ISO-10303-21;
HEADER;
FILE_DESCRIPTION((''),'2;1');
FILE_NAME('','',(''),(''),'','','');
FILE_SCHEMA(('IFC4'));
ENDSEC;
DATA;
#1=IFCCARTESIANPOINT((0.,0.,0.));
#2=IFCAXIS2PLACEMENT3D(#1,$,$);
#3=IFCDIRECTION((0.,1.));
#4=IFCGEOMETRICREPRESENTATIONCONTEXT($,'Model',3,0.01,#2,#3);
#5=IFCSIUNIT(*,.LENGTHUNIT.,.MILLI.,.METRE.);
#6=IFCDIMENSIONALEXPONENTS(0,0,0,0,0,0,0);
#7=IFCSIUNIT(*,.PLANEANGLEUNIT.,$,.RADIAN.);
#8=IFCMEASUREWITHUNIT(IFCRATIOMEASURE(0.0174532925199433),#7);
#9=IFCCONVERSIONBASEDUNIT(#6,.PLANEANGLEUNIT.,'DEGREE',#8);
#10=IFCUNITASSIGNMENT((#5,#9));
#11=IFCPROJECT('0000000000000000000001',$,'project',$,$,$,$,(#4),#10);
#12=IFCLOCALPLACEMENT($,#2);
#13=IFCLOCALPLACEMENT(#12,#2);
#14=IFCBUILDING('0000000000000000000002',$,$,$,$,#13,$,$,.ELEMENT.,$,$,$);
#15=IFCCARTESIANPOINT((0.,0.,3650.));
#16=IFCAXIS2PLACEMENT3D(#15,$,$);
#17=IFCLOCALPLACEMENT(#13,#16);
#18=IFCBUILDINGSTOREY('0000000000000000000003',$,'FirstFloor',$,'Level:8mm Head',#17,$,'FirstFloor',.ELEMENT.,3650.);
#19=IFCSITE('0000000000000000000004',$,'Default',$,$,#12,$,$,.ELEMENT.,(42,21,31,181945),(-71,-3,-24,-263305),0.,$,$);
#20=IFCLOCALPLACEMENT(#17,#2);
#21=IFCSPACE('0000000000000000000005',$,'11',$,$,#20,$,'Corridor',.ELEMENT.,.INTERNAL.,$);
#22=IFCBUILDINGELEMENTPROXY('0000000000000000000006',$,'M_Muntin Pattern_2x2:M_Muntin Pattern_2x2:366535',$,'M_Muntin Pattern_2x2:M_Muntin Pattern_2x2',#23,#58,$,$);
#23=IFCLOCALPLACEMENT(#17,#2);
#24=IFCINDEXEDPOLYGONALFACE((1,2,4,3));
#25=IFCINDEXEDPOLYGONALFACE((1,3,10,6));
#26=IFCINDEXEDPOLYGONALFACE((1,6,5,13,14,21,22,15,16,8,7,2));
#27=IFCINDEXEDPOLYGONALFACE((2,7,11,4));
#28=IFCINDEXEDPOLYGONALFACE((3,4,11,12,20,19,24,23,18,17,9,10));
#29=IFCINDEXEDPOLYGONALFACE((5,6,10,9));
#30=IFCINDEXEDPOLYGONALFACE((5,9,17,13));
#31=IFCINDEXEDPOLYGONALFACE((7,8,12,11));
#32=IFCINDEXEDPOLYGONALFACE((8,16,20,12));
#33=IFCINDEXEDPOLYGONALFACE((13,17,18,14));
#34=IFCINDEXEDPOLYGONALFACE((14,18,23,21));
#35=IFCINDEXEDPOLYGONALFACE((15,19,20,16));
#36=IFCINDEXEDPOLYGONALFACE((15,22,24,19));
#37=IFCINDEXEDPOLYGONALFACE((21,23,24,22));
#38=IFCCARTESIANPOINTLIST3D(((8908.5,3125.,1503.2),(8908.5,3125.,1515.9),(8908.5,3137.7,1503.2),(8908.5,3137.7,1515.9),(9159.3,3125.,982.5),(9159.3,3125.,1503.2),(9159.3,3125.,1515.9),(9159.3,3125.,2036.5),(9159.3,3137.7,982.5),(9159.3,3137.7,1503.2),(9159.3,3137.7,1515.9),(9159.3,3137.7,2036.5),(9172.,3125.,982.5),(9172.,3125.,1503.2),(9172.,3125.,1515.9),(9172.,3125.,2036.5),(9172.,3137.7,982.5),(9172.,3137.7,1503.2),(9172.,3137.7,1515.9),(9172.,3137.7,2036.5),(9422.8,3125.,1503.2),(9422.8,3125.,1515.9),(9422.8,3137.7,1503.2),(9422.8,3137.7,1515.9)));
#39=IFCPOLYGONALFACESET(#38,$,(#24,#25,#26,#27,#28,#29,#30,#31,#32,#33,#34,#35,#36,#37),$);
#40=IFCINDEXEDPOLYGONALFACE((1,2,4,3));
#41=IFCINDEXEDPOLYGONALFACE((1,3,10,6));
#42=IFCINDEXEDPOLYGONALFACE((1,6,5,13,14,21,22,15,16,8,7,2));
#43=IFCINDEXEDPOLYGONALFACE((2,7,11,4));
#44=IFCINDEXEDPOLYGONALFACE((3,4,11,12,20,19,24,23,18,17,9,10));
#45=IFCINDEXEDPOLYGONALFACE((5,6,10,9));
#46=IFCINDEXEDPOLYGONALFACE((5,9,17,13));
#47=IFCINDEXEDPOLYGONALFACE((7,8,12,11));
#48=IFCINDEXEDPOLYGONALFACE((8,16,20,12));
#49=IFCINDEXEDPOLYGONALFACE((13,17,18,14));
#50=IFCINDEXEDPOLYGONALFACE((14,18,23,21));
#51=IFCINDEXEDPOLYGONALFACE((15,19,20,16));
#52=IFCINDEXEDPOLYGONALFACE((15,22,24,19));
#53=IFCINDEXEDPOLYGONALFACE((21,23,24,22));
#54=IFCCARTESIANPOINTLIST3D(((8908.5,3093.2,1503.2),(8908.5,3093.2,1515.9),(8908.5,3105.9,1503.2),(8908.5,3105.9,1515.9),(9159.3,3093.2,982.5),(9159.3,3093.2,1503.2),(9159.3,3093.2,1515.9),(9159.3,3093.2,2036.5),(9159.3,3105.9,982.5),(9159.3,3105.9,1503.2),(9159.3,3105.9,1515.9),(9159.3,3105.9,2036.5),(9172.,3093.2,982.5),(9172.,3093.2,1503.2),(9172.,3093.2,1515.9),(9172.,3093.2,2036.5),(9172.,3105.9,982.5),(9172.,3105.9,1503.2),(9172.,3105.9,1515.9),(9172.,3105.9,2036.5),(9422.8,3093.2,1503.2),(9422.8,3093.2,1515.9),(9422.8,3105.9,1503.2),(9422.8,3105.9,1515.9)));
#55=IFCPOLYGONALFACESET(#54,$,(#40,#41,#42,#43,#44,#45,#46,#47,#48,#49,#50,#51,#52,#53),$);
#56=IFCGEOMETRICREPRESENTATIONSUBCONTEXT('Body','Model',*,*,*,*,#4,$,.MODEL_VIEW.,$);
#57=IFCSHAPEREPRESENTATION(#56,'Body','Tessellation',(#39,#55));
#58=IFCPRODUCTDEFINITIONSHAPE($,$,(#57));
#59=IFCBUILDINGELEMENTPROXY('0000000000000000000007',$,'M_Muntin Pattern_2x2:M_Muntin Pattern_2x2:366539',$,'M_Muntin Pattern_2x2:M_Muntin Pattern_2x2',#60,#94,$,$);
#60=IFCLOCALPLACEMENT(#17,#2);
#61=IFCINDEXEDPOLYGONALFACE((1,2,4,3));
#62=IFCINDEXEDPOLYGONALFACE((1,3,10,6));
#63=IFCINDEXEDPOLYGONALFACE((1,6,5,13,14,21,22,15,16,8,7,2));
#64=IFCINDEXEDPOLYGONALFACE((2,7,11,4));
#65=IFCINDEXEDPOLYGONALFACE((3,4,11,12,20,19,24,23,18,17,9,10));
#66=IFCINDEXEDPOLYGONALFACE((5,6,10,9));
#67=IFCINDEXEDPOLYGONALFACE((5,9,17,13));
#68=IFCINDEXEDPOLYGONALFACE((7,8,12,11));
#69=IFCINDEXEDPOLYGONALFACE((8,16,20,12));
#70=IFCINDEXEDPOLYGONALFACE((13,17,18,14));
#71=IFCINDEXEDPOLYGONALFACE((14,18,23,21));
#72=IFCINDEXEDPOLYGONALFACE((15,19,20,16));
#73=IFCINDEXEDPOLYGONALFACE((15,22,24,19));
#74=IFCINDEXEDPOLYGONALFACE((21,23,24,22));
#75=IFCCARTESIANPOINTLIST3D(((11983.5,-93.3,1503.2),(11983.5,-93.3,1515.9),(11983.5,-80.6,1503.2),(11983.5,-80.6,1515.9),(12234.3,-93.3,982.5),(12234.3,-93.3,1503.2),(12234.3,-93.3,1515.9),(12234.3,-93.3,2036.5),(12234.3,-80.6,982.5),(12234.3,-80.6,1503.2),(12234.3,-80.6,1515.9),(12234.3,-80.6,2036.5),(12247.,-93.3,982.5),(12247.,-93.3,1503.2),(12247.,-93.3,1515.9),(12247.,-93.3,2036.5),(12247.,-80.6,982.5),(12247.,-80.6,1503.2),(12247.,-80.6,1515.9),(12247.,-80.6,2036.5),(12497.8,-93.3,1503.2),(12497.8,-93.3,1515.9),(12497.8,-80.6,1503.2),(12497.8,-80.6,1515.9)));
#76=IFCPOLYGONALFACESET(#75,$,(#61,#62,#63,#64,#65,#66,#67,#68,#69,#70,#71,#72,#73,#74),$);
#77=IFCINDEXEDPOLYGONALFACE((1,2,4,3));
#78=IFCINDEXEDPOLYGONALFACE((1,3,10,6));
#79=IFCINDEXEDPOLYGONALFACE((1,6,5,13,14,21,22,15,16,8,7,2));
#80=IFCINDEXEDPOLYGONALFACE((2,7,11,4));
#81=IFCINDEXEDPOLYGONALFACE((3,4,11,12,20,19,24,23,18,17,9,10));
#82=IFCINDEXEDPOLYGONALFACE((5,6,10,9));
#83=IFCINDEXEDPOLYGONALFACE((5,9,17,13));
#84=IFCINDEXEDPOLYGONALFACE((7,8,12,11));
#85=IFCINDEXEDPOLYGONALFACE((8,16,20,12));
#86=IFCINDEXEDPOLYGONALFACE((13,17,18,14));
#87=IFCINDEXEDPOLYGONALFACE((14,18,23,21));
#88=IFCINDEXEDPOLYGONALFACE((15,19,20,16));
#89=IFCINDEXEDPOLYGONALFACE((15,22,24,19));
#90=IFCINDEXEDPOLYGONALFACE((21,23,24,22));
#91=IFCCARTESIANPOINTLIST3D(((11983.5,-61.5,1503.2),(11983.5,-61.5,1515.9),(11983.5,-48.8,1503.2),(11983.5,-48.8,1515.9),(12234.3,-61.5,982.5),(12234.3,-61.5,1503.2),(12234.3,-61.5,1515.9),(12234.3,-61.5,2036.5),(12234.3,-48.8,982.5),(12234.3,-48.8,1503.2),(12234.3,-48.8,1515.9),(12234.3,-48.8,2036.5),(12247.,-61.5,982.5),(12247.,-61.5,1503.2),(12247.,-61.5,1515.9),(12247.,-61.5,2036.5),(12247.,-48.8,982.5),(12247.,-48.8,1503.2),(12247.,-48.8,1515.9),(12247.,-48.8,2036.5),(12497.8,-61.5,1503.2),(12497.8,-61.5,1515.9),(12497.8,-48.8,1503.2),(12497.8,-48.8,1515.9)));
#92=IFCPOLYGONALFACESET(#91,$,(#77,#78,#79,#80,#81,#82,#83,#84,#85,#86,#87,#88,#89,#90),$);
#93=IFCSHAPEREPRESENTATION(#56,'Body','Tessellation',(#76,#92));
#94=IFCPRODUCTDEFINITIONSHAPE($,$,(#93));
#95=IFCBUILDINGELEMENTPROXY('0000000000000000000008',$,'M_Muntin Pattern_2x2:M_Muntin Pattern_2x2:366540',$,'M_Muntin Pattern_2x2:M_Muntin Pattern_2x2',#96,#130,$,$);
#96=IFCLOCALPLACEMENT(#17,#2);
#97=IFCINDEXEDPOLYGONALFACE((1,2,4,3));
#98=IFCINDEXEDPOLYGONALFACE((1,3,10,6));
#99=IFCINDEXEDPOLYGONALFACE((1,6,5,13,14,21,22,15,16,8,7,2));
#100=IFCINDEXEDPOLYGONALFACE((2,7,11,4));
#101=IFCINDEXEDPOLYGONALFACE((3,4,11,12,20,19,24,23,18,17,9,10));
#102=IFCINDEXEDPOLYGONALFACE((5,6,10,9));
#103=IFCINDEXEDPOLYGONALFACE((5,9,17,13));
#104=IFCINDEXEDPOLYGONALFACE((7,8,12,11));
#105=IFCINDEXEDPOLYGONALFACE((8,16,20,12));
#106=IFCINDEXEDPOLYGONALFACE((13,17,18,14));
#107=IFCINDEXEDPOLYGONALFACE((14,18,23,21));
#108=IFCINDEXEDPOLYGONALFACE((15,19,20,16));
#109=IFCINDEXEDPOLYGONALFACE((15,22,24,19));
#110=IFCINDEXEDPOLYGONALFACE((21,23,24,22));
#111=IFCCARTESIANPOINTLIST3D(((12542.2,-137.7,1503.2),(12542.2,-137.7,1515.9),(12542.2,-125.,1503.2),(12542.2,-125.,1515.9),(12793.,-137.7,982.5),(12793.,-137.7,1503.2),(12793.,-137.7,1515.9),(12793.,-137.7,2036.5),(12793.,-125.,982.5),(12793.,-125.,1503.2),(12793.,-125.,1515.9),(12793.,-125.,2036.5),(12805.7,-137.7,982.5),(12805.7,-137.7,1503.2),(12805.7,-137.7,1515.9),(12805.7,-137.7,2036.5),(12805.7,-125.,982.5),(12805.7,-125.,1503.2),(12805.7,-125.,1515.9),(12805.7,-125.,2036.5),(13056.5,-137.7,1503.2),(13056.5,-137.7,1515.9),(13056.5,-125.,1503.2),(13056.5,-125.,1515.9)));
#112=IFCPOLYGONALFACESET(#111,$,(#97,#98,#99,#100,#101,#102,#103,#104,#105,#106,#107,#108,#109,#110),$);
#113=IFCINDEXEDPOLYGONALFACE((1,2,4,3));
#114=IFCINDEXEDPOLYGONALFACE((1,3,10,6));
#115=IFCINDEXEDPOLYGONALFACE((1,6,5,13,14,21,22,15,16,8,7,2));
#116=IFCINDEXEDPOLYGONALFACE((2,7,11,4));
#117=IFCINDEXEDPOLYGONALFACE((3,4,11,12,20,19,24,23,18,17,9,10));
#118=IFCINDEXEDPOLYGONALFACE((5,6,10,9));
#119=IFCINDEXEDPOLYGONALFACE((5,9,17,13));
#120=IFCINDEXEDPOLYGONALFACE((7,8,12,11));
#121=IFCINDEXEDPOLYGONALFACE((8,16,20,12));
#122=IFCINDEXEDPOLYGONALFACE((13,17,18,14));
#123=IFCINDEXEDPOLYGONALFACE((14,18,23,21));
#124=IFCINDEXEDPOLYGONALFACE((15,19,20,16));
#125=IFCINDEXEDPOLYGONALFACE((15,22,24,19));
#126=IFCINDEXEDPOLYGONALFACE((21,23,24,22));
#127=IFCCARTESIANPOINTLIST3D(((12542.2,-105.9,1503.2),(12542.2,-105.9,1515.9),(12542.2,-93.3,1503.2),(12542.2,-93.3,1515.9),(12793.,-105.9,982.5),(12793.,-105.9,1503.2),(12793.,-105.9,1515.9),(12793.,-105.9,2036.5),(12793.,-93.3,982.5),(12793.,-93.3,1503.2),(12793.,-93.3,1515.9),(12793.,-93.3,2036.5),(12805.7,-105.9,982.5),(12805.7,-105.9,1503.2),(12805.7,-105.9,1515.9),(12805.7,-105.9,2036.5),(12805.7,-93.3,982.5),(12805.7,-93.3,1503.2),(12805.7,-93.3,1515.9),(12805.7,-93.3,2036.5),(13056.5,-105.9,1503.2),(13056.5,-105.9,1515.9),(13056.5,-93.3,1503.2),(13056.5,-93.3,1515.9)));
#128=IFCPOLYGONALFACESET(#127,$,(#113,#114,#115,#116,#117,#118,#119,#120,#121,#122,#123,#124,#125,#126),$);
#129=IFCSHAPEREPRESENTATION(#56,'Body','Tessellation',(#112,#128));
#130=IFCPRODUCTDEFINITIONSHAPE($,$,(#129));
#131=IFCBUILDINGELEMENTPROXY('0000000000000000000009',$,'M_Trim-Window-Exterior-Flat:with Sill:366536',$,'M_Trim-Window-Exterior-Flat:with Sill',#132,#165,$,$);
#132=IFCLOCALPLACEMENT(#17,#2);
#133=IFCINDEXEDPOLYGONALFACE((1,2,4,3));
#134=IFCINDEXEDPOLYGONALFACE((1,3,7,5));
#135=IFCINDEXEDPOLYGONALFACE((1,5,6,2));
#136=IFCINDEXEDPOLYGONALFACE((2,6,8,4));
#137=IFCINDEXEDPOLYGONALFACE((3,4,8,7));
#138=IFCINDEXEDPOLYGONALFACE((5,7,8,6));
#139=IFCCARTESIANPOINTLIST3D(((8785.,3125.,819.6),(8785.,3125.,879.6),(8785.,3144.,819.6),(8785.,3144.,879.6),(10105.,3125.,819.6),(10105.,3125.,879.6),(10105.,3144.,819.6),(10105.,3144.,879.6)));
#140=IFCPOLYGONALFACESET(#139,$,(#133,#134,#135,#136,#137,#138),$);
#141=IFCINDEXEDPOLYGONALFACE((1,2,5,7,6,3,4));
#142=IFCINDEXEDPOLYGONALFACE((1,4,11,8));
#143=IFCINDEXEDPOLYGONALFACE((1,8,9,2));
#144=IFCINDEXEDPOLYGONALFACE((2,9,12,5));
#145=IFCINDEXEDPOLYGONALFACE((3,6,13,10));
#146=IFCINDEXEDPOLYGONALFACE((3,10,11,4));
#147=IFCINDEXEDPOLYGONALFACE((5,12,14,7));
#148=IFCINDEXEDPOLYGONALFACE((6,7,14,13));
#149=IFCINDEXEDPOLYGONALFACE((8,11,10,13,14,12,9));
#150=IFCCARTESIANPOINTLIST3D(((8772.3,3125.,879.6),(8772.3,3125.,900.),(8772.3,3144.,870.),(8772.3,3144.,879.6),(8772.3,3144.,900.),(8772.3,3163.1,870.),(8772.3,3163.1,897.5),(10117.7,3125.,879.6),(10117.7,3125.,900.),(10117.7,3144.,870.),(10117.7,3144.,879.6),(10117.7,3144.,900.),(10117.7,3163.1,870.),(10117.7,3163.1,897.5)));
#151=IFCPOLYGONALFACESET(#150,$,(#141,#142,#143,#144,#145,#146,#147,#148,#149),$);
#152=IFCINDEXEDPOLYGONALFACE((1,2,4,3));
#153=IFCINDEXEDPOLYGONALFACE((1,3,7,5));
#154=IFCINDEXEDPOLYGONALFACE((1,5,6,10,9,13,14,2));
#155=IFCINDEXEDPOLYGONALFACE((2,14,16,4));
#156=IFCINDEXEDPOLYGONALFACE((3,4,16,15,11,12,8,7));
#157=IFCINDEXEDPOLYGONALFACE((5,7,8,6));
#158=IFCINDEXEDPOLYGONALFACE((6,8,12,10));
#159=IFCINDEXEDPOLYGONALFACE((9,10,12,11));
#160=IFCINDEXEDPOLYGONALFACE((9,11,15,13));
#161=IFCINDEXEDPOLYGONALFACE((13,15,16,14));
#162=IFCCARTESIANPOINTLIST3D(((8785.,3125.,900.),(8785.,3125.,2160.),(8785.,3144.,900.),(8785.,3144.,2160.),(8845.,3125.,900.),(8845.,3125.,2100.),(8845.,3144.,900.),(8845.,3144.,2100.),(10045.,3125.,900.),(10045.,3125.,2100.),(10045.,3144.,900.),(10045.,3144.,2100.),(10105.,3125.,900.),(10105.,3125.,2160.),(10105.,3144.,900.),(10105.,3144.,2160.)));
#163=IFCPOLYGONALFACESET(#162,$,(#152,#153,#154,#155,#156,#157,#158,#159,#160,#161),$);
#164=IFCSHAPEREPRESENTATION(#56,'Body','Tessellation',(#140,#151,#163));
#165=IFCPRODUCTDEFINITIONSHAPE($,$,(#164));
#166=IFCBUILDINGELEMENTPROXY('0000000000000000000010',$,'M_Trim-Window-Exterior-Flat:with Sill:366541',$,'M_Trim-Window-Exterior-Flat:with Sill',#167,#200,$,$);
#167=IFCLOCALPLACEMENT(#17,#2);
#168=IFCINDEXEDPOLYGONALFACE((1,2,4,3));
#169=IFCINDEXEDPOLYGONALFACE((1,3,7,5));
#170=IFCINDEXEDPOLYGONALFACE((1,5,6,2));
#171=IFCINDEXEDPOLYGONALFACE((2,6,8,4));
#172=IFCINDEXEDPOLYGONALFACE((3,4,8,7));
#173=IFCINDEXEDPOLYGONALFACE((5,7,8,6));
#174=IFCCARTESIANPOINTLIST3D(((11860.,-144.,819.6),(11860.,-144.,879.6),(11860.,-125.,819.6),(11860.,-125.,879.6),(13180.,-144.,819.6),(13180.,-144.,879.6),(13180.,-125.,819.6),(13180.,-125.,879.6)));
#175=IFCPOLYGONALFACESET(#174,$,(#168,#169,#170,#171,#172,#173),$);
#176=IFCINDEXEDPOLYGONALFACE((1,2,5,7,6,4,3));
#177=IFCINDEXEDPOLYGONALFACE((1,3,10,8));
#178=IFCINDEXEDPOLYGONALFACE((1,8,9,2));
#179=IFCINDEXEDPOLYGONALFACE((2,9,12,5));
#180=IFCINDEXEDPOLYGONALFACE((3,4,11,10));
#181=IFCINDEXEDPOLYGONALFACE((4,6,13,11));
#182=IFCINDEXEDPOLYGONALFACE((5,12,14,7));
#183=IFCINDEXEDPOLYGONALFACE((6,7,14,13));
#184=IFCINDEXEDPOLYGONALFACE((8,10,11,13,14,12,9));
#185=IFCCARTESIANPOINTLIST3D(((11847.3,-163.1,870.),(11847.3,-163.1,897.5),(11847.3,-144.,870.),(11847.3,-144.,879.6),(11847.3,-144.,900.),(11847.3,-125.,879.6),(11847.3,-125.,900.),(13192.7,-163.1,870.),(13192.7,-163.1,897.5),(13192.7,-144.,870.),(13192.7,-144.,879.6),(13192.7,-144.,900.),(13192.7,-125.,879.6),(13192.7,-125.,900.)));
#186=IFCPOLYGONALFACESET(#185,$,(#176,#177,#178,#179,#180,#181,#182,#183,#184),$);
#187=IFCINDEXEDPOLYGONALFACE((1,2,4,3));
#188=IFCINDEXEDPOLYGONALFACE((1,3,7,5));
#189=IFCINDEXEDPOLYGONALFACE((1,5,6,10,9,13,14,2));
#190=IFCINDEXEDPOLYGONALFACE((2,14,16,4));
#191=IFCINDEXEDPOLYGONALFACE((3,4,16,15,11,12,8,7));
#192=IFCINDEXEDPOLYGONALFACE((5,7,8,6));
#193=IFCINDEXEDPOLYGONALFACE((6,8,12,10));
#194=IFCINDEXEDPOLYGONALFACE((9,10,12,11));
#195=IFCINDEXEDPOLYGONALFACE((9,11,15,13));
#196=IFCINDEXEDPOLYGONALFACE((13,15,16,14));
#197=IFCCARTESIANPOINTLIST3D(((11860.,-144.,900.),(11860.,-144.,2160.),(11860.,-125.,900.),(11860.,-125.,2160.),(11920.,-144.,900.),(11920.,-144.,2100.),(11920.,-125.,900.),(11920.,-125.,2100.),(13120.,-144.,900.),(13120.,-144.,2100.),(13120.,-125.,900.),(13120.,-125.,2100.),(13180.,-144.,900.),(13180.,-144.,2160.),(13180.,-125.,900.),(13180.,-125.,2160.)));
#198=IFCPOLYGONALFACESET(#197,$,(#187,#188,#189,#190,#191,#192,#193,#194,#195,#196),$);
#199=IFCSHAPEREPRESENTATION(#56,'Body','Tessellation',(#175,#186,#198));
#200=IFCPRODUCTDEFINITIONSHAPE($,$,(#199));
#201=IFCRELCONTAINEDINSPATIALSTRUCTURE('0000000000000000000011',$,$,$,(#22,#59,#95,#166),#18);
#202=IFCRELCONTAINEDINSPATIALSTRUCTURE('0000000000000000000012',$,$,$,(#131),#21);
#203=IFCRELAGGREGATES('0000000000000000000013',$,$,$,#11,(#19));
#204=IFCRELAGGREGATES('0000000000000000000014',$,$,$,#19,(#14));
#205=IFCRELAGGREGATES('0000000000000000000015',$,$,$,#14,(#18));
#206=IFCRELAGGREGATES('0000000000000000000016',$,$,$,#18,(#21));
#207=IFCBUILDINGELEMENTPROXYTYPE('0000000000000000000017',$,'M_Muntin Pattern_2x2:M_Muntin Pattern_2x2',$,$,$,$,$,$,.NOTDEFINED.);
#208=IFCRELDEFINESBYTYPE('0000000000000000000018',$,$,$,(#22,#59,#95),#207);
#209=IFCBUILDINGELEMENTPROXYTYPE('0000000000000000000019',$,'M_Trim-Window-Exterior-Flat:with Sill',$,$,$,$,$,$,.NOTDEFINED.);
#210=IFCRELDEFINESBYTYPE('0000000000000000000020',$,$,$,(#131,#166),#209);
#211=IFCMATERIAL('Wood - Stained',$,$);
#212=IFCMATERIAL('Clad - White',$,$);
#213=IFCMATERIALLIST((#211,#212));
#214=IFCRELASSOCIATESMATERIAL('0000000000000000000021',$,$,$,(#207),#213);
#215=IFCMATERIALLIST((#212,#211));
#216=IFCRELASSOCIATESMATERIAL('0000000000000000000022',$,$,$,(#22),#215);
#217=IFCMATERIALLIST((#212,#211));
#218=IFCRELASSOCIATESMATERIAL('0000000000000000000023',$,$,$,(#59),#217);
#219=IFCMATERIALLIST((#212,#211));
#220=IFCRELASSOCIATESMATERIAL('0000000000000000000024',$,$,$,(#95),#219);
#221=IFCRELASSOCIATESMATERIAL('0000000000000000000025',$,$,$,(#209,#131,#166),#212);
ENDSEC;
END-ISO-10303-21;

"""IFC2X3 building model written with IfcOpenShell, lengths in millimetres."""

from ifc_helpers import new_model, entity, si_unit, converted_unit, direction, frame, frame_2d, origin, place, context, subcontext, project, spatial, polyline, rectangle, outline, extrude, source, transform, mapped, material, material_list, type_object, type_shapes, element, save


model = new_model("IFC2X3")

# Units and contexts
model_context = context("Model", 3, precision=0.01, world=origin(), true_north=direction((0.0, 1.0)))
body_context = subcontext(model_context, "Body", "Model", "MODEL_VIEW")
ifc_project = project(units=[si_unit("LENGTHUNIT", "METRE", prefix="MILLI"), converted_unit("PLANEANGLEUNIT", "DEGREE", entity("IfcRatioMeasure", 0.0174532925199433), si_unit("PLANEANGLEUNIT", "RADIAN"), dimensions=[0, 0, 0, 0, 0, 0, 0])], contexts=[model_context])

# Site, building, storey
site_placement = place(None, origin())
site = spatial("IfcSite", under=ifc_project, at=site_placement, Name="Default", CompositionType="ELEMENT", RefLatitude=(42, 21, 31, 181945), RefLongitude=(-71, -3, -24, -263305), RefElevation=0.0)
building_placement = place(site_placement, origin())
building = spatial("IfcBuilding", under=site, at=building_placement, CompositionType="ELEMENT")
storey_placement = place(building_placement, frame((0.0, 0.0, 3650.0)))
storey = spatial("IfcBuildingStorey", under=building, at=storey_placement, Name="FirstFloor", ObjectType="Level:8mm Head", LongName="FirstFloor", CompositionType="ELEMENT", Elevation=3650.0)

# Building element proxies
ifc_material_1 = material(Name="Clad - White")
ifc_material_2 = material(Name="Wood - Stained")
ifc_material_list_1 = material_list([ifc_material_2, ifc_material_1])
building_element_proxy_type_1 = type_object("IfcBuildingElementProxyType", Name="M_Muntin Pattern_2x2:M_Muntin Pattern_2x2", PredefinedType="NOTDEFINED", material=ifc_material_list_1)
shared_shape_1 = source(origin(), body_context, "Body", "SweptSolid", [
    extrude(outline(polyline([(6.4, -6.4), (527.0, -6.4), (527.0, 6.3), (6.4, 6.3), (6.4, 257.1), (-6.3, 257.1), (-6.3, 6.3), (-527.0, 6.3), (-527.0, -6.4), (-6.3, -6.4), (-6.3, -257.1), (6.4, -257.1), (6.4, -6.4)])), frame((0.0, 9.5, 527.0), z_axis=(0.0, 1.0, 0.0), x_axis=(0.0, 0.0, 1.0)), (0.0, 0.0, 1.0), 12.7),
    extrude(outline(polyline([(6.4, -6.4), (527.0, -6.4), (527.0, 6.3), (6.4, 6.3), (6.4, 257.1), (-6.3, 257.1), (-6.3, 6.3), (-527.0, 6.3), (-527.0, -6.4), (-6.3, -6.4), (-6.3, -257.1), (6.4, -257.1), (6.4, -6.4)])), frame((0.0, -22.2, 527.0), z_axis=(0.0, 1.0, 0.0), x_axis=(0.0, 0.0, 1.0)), (0.0, 0.0, 1.0), 12.7),
])
type_shapes(building_element_proxy_type_1, [shared_shape_1])
ifc_material_list_2 = material_list([ifc_material_1, ifc_material_2])
proxy_1_placement = place(storey_placement, frame((9165.6, 3115.5, 982.5)))
element("IfcBuildingElementProxy", 1, at=proxy_1_placement, inside=storey, type_object=building_element_proxy_type_1, material=ifc_material_list_2, Name="M_Muntin Pattern_2x2:M_Muntin Pattern_2x2:366535", ObjectType="M_Muntin Pattern_2x2:M_Muntin Pattern_2x2", context=body_context, shape_type="MappedRepresentation", body=[
    mapped(shared_shape_1, transform((0.0, 0.0, 0.0), scale=1.0)),
])
ifc_material_list_3 = material_list([ifc_material_1, ifc_material_2])
proxy_2_placement = place(storey_placement, frame((12240.6, -71.0, 982.5), z_axis=(0.0, 0.0, 1.0), x_axis=(-1.0, 0.0, 0.0)))
element("IfcBuildingElementProxy", 2, at=proxy_2_placement, inside=storey, type_object=building_element_proxy_type_1, material=ifc_material_list_3, Name="M_Muntin Pattern_2x2:M_Muntin Pattern_2x2:366539", ObjectType="M_Muntin Pattern_2x2:M_Muntin Pattern_2x2", context=body_context, shape_type="MappedRepresentation", body=[
    mapped(shared_shape_1, transform((0.0, 0.0, 0.0), scale=1.0)),
])
ifc_material_list_4 = material_list([ifc_material_1, ifc_material_2])
proxy_3_placement = place(storey_placement, frame((12799.4, -115.5, 982.5), z_axis=(0.0, 0.0, 1.0), x_axis=(-1.0, 0.0, 0.0)))
element("IfcBuildingElementProxy", 3, at=proxy_3_placement, inside=storey, type_object=building_element_proxy_type_1, material=ifc_material_list_4, Name="M_Muntin Pattern_2x2:M_Muntin Pattern_2x2:366540", ObjectType="M_Muntin Pattern_2x2:M_Muntin Pattern_2x2", context=body_context, shape_type="MappedRepresentation", body=[
    mapped(shared_shape_1, transform((0.0, 0.0, 0.0), scale=1.0)),
])

# Shared definitions
space_1_placement = place(storey_placement, origin())
space_1 = spatial("IfcSpace", under=storey, at=space_1_placement, Name="11", LongName="Corridor", CompositionType="ELEMENT", InteriorOrExteriorSpace="INTERNAL")

# Building element proxies
building_element_proxy_type_2 = type_object("IfcBuildingElementProxyType", Name="M_Trim-Window-Exterior-Flat:with Sill", PredefinedType="NOTDEFINED", material=ifc_material_1)
shared_shape_2 = source(origin(), body_context, "Body", "SweptSolid", [
    extrude(rectangle(XDim=1320.0, YDim=60.0, at=frame_2d((0.0, 0.0), x_axis=(1.0, 0.0))), frame((0.0, -1250.4, 0.0), z_axis=(0.0, 0.0, 1.0), x_axis=(-1.0, 0.0, 0.0)), (0.0, 0.0, 1.0), 19.1),
    extrude(outline(polyline([(-19.0, -15.2), (0.0, -15.2), (0.0, -5.7), (19.0, -5.7), (19.0, 14.8), (0.0, 14.8), (-19.0, 12.3), (-19.0, -15.2)])), frame((-672.7, -1214.8, 19.0), z_axis=(1.0, 0.0, 0.0), x_axis=(0.0, 0.0, -1.0)), (0.0, 0.0, 1.0), 1345.4),
    extrude(outline(polyline([(-645.0, -660.0), (615.0, -660.0), (615.0, -600.0), (-585.0, -600.0), (-585.0, 600.0), (615.0, 600.0), (615.0, 660.0), (-645.0, 660.0), (-645.0, -660.0)])), frame((0.0, -585.0, 0.0), z_axis=(0.0, 0.0, 1.0), x_axis=(0.0, -1.0, 0.0)), (0.0, 0.0, 1.0), 19.1),
])
type_shapes(building_element_proxy_type_2, [shared_shape_2])
proxy_4_placement = place(space_1_placement, frame((9445.0, 3125.0, 2100.0), z_axis=(0.0, 1.0, 0.0), x_axis=(-1.0, 0.0, 0.0)))
element("IfcBuildingElementProxy", 4, at=proxy_4_placement, inside=space_1, type_object=building_element_proxy_type_2, material=ifc_material_1, Name="M_Trim-Window-Exterior-Flat:with Sill:366536", ObjectType="M_Trim-Window-Exterior-Flat:with Sill", context=body_context, shape_type="MappedRepresentation", body=[
    mapped(shared_shape_2, transform((0.0, 0.0, 0.0), scale=1.0)),
])
proxy_5_placement = place(storey_placement, frame((12520.0, -125.0, 2100.0), z_axis=(0.0, -1.0, 0.0), x_axis=(1.0, 0.0, 0.0)))
element("IfcBuildingElementProxy", 5, at=proxy_5_placement, inside=storey, type_object=building_element_proxy_type_2, material=ifc_material_1, Name="M_Trim-Window-Exterior-Flat:with Sill:366541", ObjectType="M_Trim-Window-Exterior-Flat:with Sill", context=body_context, shape_type="MappedRepresentation", body=[
    mapped(shared_shape_2, transform((0.0, 0.0, 0.0), scale=1.0)),
])

save(model, "model.ifc")
